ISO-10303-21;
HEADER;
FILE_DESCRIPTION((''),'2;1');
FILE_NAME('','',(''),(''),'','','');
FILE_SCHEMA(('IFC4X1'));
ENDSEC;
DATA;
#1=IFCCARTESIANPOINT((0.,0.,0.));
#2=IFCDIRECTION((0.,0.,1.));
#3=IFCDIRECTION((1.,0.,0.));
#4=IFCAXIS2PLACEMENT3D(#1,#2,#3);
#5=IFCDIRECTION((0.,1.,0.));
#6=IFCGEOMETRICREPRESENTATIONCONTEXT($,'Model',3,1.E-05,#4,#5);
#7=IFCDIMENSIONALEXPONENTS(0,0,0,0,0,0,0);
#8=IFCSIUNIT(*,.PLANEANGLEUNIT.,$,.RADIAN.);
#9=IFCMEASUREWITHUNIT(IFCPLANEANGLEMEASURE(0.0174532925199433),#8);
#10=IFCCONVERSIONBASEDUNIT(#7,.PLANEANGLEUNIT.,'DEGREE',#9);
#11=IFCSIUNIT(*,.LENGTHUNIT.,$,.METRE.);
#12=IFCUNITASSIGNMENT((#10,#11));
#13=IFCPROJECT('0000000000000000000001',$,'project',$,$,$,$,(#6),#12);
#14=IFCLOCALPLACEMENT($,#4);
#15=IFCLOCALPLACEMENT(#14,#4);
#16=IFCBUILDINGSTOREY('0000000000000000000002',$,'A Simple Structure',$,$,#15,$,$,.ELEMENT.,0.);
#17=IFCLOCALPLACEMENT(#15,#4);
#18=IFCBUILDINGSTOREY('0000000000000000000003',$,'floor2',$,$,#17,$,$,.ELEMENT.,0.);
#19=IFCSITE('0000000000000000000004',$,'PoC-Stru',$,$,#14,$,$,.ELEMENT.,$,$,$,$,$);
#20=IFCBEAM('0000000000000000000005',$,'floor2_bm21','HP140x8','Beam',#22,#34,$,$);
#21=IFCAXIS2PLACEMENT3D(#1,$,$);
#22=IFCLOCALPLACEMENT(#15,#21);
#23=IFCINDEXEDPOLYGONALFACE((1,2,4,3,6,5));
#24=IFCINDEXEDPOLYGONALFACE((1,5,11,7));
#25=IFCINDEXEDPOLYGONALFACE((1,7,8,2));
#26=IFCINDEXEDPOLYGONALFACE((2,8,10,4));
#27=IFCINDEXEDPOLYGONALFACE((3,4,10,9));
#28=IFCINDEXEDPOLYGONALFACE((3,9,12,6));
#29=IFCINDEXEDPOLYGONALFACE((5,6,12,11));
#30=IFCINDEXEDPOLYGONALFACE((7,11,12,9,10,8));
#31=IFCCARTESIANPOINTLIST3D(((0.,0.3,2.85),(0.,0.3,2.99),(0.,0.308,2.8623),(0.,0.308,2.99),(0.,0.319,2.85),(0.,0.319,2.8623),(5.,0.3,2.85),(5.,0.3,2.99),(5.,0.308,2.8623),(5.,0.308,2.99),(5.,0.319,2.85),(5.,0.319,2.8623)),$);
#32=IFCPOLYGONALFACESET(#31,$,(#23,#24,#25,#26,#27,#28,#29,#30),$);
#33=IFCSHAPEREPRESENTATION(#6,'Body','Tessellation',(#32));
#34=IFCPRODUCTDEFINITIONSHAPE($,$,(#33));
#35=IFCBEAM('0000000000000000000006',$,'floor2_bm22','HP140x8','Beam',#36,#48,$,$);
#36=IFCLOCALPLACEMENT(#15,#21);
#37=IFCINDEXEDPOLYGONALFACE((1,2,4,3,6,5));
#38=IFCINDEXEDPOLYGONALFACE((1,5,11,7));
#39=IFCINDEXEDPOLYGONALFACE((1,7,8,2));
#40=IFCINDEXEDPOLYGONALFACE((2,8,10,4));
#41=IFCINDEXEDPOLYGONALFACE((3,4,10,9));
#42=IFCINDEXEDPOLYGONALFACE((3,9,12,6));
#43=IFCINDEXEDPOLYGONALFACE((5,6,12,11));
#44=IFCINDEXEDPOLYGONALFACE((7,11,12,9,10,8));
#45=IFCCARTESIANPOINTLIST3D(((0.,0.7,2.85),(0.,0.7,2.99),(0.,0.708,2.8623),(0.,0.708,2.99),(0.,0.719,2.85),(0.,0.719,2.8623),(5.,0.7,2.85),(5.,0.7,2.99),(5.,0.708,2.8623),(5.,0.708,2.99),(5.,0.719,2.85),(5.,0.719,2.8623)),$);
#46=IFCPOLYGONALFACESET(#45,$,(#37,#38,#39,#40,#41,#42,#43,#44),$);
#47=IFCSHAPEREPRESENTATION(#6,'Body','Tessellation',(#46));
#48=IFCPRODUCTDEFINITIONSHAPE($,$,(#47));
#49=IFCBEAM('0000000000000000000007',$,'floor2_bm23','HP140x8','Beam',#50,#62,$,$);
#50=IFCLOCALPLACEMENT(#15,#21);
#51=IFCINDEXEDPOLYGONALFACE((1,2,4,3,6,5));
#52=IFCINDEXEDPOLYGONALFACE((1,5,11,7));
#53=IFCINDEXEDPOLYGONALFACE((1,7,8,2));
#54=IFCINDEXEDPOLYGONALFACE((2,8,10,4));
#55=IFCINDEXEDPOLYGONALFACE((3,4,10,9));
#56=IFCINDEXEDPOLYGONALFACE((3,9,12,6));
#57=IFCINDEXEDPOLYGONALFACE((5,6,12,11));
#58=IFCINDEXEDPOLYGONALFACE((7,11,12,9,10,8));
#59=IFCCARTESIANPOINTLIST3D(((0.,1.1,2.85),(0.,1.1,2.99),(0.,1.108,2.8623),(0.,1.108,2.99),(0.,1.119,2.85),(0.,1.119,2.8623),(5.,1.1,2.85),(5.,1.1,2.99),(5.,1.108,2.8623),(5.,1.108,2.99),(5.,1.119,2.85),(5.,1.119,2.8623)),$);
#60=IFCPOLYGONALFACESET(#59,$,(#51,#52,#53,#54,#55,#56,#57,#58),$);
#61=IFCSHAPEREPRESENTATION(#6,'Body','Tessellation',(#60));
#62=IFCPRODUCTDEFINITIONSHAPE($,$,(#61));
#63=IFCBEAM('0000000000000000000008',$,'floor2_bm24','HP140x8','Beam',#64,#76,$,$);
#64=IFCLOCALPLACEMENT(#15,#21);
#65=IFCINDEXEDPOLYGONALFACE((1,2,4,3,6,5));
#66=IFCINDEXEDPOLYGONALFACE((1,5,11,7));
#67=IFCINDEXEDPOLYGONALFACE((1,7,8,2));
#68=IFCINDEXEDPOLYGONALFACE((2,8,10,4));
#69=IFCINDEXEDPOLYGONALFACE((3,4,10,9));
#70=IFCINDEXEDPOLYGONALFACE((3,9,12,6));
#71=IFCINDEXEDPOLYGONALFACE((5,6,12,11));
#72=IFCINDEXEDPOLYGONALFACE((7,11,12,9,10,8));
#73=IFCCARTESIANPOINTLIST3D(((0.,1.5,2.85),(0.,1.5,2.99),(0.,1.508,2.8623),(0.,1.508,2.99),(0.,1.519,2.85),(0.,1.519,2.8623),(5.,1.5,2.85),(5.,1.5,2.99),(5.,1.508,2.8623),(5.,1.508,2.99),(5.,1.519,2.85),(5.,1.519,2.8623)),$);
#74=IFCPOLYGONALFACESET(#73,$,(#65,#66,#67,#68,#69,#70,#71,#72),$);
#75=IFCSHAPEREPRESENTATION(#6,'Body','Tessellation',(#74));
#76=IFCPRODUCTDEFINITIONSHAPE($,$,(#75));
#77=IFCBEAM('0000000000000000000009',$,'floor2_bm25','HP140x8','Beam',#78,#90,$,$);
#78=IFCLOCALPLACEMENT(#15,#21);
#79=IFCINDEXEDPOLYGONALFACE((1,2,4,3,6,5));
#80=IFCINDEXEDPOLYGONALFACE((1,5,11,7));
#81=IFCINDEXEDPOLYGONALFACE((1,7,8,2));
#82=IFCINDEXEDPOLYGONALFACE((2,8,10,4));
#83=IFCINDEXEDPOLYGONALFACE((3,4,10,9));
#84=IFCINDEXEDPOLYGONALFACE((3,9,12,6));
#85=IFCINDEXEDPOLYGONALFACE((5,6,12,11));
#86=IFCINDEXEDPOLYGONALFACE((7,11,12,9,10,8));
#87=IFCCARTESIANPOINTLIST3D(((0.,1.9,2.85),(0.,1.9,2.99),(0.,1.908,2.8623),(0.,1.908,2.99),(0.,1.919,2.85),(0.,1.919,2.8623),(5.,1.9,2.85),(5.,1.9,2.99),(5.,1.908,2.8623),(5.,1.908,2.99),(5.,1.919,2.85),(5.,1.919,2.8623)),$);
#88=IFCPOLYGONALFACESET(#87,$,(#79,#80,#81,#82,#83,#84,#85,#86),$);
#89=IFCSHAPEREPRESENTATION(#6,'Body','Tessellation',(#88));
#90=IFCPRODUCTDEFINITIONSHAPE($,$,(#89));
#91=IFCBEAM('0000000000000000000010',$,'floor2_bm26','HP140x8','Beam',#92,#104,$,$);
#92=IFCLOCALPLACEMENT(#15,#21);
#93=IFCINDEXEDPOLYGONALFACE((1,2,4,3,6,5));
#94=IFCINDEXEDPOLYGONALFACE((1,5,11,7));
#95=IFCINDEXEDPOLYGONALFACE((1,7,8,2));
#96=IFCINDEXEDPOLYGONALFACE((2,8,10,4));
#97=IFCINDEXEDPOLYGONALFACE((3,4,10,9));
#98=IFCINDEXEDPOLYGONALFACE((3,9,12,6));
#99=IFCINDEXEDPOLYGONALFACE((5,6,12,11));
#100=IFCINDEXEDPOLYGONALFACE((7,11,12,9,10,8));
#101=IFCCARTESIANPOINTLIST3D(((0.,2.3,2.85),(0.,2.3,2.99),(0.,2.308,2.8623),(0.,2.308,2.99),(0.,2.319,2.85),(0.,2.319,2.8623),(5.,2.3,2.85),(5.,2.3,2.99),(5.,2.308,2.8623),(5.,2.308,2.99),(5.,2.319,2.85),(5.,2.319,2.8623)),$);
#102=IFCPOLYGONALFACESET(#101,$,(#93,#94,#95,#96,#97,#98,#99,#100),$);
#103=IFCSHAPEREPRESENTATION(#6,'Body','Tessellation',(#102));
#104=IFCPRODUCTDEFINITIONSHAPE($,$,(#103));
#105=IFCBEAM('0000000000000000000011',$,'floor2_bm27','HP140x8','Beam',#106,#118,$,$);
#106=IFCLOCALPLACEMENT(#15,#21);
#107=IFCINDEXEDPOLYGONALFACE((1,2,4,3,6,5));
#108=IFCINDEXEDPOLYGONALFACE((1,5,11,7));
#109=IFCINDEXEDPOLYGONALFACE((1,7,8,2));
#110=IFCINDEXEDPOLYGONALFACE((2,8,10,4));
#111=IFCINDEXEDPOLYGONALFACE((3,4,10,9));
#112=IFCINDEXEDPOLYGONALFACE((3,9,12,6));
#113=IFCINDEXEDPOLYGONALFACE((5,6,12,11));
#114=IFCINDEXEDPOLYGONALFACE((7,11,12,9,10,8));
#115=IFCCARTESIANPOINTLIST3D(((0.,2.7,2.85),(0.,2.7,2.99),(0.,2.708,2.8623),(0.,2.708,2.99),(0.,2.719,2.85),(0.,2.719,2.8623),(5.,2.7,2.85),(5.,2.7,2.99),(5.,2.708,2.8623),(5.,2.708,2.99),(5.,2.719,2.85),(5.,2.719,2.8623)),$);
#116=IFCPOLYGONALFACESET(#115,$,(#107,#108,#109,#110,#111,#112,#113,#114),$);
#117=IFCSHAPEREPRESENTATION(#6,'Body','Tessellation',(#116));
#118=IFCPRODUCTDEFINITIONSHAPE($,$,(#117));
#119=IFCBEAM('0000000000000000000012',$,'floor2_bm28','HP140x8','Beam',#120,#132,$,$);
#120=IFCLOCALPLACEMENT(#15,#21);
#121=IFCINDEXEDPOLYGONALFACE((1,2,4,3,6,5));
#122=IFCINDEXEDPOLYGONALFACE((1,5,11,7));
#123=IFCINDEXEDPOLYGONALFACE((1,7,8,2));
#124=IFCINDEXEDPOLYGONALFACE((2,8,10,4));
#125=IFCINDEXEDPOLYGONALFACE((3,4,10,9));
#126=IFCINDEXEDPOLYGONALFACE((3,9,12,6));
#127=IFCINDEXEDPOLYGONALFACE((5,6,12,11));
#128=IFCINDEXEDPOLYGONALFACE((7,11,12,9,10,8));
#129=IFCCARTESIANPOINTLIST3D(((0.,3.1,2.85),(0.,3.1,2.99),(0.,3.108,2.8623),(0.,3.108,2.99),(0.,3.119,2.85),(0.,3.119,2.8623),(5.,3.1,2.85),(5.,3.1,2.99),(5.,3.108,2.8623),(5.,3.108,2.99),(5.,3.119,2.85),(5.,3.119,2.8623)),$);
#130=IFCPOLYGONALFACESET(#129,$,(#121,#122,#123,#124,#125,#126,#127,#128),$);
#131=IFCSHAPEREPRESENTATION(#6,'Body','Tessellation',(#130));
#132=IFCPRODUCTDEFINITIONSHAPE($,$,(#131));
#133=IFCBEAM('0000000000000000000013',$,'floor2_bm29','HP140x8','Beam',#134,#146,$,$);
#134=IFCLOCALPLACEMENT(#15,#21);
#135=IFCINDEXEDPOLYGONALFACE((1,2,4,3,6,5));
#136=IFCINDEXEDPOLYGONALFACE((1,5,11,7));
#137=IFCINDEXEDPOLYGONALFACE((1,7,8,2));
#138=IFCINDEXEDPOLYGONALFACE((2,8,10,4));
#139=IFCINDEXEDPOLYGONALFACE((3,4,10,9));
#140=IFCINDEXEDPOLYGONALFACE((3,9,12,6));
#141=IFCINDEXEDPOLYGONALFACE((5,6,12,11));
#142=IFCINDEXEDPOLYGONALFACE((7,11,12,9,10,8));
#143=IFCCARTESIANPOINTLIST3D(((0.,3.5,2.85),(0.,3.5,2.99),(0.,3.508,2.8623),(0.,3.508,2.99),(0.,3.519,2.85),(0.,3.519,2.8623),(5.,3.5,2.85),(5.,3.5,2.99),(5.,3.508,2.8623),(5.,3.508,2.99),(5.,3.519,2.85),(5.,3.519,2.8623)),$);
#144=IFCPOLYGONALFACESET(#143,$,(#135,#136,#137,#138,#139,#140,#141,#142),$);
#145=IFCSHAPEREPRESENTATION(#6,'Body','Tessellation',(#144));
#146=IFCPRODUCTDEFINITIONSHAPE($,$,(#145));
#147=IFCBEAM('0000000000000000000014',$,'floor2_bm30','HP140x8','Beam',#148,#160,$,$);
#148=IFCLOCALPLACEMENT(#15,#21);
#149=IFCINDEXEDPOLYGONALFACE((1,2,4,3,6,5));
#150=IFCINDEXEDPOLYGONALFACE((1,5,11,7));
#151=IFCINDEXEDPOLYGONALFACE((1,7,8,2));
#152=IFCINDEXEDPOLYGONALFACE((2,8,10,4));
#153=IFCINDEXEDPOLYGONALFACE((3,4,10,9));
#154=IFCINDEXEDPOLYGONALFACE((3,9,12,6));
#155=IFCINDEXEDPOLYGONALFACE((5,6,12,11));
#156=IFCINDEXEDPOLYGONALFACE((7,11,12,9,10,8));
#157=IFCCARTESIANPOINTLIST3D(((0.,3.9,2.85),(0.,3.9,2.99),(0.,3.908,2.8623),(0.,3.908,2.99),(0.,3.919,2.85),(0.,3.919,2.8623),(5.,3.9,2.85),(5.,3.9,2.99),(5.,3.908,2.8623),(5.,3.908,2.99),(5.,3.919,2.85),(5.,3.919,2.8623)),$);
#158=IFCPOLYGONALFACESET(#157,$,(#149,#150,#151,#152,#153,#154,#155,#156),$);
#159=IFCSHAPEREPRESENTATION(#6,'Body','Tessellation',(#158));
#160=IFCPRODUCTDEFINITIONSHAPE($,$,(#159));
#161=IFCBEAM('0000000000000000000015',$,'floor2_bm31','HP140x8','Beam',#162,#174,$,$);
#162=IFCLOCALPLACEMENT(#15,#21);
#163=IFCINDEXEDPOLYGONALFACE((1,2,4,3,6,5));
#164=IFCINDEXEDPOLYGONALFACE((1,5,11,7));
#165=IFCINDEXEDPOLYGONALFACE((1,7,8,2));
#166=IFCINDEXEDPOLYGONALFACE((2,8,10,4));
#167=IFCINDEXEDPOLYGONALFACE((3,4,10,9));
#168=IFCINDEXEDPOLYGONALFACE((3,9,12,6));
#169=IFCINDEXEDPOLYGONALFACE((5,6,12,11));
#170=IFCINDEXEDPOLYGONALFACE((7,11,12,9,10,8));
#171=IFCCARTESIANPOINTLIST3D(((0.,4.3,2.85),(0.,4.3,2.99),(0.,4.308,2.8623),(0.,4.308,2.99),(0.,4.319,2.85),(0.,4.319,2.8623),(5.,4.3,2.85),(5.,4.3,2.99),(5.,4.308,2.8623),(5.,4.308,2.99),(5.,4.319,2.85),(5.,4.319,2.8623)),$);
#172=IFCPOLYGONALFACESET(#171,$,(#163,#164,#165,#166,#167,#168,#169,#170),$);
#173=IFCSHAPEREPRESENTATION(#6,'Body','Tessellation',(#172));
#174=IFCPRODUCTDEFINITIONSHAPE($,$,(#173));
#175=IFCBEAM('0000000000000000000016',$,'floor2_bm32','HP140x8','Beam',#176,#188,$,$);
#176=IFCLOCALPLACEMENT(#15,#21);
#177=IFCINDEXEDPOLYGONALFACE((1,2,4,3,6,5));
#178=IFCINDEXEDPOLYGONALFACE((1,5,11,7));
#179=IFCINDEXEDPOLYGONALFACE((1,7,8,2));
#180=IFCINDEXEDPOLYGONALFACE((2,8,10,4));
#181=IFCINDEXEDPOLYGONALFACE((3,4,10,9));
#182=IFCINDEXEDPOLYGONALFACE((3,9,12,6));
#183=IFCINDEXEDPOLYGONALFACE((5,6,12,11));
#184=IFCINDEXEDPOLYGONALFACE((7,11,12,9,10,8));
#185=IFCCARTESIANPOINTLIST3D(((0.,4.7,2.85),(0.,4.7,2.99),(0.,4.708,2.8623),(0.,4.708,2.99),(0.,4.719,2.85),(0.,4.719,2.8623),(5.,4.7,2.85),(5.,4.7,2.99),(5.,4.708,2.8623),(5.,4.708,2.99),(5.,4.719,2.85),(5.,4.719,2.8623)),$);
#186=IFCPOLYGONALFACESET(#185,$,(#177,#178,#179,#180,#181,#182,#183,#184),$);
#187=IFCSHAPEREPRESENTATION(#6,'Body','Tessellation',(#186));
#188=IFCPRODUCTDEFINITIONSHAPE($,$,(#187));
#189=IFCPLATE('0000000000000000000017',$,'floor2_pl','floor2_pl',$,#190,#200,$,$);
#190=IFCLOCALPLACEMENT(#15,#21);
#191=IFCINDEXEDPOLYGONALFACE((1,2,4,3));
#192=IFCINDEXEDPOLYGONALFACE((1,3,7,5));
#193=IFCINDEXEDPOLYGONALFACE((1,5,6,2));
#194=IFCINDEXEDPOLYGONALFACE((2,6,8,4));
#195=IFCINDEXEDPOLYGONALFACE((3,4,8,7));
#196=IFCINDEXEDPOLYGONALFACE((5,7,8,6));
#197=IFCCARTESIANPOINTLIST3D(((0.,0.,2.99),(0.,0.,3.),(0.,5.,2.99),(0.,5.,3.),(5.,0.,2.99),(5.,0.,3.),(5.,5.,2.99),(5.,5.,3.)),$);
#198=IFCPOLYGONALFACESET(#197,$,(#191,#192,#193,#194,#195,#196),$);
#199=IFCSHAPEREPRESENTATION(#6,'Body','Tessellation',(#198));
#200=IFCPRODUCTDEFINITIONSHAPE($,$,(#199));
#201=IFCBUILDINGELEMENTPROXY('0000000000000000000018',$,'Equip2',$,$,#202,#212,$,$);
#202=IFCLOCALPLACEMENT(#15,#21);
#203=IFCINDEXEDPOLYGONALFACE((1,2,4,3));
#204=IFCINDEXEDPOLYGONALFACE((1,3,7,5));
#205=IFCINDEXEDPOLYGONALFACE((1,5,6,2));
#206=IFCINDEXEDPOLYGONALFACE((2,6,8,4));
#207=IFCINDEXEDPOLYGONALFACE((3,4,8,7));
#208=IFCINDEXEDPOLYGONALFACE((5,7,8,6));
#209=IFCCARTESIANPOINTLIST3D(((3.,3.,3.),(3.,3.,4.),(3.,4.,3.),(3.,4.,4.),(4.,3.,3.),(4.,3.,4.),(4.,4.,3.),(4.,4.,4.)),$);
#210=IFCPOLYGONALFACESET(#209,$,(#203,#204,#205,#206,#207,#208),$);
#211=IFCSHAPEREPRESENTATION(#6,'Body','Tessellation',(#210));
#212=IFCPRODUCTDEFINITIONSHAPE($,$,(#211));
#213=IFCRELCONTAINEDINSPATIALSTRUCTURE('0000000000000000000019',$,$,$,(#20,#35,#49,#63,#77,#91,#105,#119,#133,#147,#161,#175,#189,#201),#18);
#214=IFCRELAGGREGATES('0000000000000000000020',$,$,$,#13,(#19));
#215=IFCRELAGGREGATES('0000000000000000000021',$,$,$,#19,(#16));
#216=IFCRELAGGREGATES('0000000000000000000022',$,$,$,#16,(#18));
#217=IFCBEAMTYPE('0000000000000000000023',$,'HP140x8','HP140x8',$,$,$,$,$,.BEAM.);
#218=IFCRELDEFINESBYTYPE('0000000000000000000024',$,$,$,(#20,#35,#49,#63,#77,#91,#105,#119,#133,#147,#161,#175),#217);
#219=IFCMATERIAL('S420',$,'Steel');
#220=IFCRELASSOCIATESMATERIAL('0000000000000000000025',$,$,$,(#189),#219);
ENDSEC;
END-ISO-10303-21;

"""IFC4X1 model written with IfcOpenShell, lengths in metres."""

from ifc_helpers import new_model, entity, si_unit, converted_unit, direction, frame, origin, origin_with_axes, place, context, project, spatial, polyline, line, indexed_curve, outline, extrude, material, type_object, element, save


model = new_model("IFC4X1")

# Units and contexts
model_context = context("Model", 3, precision=1e-05, world=origin_with_axes(), true_north=direction((0.0, 1.0, 0.0)))
ifc_project = project(units=[converted_unit("PLANEANGLEUNIT", "DEGREE", entity("IfcPlaneAngleMeasure", 0.0174532925199433), si_unit("PLANEANGLEUNIT", "RADIAN"), dimensions=[0, 0, 0, 0, 0, 0, 0]), si_unit("LENGTHUNIT", "METRE")], contexts=[model_context])

# Site, storeys
site_placement = place(None, origin_with_axes())
site = spatial("IfcSite", under=ifc_project, at=site_placement, Name="PoC-Stru", CompositionType="ELEMENT")
storey_1_placement = place(site_placement, origin_with_axes())
storey_1 = spatial("IfcBuildingStorey", under=site, at=storey_1_placement, Name="A Simple Structure", CompositionType="ELEMENT", Elevation=0.0)
storey_2_placement = place(storey_1_placement, origin_with_axes())
storey_2 = spatial("IfcBuildingStorey", under=storey_1, at=storey_2_placement, Name="floor2", CompositionType="ELEMENT", Elevation=0.0)

# Beams
beam_type = type_object("IfcBeamType", Name="HP140x8", Description="HP140x8", PredefinedType="BEAM")
plate_placement = place(storey_2_placement, origin_with_axes())
for number, where, z_axis, x_axis, name in (
    (1, (0.0, 0.3, 2.99), (1.0, 0.0, 0.0), (0.0, 1.0, 0.0), "floor2_bm21"),
    (2, (0.0, 0.7, 2.99), (1.0, 0.0, 0.0), (0.0, 1.0, 0.0), "floor2_bm22"),
    (3, (0.0, 1.1, 2.99), (1.0, 0.0, 0.0), (0.0, 1.0, 0.0), "floor2_bm23"),
    (4, (0.0, 1.5, 2.99), (1.0, 0.0, 0.0), (0.0, 1.0, 0.0), "floor2_bm24"),
    (5, (0.0, 1.9, 2.99), (1.0, 0.0, 0.0), (0.0, 1.0, 0.0), "floor2_bm25"),
    (6, (0.0, 2.3, 2.99), (1.0, 0.0, 0.0), (0.0, 1.0, 0.0), "floor2_bm26"),
    (7, (0.0, 2.7, 2.99), (1.0, 0.0, 0.0), (0.0, 1.0, 0.0), "floor2_bm27"),
    (8, (0.0, 3.1, 2.99), (1.0, 0.0, 0.0), (0.0, 1.0, 0.0), "floor2_bm28"),
    (9, (0.0, 3.5, 2.99), (1.0, 0.0, 0.0), (0.0, 1.0, 0.0), "floor2_bm29"),
    (10, (0.0, 3.9, 2.99), (1.0, 0.0, 0.0), (0.0, 1.0, 0.0), "floor2_bm30"),
    (11, (0.0, 4.3, 2.99), (1.0, 0.0, 0.0), (0.0, 1.0, 0.0), "floor2_bm31"),
    (12, (0.0, 4.7, 2.99), (1.0, 0.0, 0.0), (0.0, 1.0, 0.0), "floor2_bm32"),
):
    element("IfcBeam", number, at=place(plate_placement, frame(where, z_axis=z_axis, x_axis=x_axis)), inside=storey_2, type_object=beam_type, Name=name, Description="HP140x8", ObjectType="Beam", context=model_context, shape_type="SweptSolid", body=[
        extrude(outline(polyline([(0.0, 0.0), (0.008, 0.0), (0.008, -0.1277), (0.019, -0.1277), (0.019, -0.14), (0.0, -0.14)])), origin(), (0.0, 0.0, 1.0), 5.0),
    ])

# Plate
ifc_material = material(Name="S420", Category="Steel")
element("IfcPlate", 13, at=plate_placement, inside=storey_2, material=ifc_material, Name="floor2_pl", Description="floor2_pl", context=model_context, shape_type="SolidModel", body=[
    extrude(outline(indexed_curve([(0.0, 5.0, 3.0), (0.0, 0.0, 3.0), (5.0, 0.0, 3.0), (5.0, 5.0, 3.0)], segments=[line(1, 2), line(2, 3), line(3, 4), line(4, 1)])), origin_with_axes(), (0.0, 0.0, -1.0), 0.01),
])

# Building element proxy
proxy_placement = place(storey_2_placement, origin_with_axes())
element("IfcBuildingElementProxy", 14, at=proxy_placement, inside=storey_2, Name="Equip2", context=model_context, shape_type="SweptSolid", body=[
    extrude(outline(polyline([(3.0, 3.0, 3.0), (3.0, 4.0, 3.0), (4.0, 4.0, 3.0), (4.0, 3.0, 3.0)])), origin_with_axes(), (0.0, 0.0, 1.0), 1.0),
])

save(model, "model.ifc")
